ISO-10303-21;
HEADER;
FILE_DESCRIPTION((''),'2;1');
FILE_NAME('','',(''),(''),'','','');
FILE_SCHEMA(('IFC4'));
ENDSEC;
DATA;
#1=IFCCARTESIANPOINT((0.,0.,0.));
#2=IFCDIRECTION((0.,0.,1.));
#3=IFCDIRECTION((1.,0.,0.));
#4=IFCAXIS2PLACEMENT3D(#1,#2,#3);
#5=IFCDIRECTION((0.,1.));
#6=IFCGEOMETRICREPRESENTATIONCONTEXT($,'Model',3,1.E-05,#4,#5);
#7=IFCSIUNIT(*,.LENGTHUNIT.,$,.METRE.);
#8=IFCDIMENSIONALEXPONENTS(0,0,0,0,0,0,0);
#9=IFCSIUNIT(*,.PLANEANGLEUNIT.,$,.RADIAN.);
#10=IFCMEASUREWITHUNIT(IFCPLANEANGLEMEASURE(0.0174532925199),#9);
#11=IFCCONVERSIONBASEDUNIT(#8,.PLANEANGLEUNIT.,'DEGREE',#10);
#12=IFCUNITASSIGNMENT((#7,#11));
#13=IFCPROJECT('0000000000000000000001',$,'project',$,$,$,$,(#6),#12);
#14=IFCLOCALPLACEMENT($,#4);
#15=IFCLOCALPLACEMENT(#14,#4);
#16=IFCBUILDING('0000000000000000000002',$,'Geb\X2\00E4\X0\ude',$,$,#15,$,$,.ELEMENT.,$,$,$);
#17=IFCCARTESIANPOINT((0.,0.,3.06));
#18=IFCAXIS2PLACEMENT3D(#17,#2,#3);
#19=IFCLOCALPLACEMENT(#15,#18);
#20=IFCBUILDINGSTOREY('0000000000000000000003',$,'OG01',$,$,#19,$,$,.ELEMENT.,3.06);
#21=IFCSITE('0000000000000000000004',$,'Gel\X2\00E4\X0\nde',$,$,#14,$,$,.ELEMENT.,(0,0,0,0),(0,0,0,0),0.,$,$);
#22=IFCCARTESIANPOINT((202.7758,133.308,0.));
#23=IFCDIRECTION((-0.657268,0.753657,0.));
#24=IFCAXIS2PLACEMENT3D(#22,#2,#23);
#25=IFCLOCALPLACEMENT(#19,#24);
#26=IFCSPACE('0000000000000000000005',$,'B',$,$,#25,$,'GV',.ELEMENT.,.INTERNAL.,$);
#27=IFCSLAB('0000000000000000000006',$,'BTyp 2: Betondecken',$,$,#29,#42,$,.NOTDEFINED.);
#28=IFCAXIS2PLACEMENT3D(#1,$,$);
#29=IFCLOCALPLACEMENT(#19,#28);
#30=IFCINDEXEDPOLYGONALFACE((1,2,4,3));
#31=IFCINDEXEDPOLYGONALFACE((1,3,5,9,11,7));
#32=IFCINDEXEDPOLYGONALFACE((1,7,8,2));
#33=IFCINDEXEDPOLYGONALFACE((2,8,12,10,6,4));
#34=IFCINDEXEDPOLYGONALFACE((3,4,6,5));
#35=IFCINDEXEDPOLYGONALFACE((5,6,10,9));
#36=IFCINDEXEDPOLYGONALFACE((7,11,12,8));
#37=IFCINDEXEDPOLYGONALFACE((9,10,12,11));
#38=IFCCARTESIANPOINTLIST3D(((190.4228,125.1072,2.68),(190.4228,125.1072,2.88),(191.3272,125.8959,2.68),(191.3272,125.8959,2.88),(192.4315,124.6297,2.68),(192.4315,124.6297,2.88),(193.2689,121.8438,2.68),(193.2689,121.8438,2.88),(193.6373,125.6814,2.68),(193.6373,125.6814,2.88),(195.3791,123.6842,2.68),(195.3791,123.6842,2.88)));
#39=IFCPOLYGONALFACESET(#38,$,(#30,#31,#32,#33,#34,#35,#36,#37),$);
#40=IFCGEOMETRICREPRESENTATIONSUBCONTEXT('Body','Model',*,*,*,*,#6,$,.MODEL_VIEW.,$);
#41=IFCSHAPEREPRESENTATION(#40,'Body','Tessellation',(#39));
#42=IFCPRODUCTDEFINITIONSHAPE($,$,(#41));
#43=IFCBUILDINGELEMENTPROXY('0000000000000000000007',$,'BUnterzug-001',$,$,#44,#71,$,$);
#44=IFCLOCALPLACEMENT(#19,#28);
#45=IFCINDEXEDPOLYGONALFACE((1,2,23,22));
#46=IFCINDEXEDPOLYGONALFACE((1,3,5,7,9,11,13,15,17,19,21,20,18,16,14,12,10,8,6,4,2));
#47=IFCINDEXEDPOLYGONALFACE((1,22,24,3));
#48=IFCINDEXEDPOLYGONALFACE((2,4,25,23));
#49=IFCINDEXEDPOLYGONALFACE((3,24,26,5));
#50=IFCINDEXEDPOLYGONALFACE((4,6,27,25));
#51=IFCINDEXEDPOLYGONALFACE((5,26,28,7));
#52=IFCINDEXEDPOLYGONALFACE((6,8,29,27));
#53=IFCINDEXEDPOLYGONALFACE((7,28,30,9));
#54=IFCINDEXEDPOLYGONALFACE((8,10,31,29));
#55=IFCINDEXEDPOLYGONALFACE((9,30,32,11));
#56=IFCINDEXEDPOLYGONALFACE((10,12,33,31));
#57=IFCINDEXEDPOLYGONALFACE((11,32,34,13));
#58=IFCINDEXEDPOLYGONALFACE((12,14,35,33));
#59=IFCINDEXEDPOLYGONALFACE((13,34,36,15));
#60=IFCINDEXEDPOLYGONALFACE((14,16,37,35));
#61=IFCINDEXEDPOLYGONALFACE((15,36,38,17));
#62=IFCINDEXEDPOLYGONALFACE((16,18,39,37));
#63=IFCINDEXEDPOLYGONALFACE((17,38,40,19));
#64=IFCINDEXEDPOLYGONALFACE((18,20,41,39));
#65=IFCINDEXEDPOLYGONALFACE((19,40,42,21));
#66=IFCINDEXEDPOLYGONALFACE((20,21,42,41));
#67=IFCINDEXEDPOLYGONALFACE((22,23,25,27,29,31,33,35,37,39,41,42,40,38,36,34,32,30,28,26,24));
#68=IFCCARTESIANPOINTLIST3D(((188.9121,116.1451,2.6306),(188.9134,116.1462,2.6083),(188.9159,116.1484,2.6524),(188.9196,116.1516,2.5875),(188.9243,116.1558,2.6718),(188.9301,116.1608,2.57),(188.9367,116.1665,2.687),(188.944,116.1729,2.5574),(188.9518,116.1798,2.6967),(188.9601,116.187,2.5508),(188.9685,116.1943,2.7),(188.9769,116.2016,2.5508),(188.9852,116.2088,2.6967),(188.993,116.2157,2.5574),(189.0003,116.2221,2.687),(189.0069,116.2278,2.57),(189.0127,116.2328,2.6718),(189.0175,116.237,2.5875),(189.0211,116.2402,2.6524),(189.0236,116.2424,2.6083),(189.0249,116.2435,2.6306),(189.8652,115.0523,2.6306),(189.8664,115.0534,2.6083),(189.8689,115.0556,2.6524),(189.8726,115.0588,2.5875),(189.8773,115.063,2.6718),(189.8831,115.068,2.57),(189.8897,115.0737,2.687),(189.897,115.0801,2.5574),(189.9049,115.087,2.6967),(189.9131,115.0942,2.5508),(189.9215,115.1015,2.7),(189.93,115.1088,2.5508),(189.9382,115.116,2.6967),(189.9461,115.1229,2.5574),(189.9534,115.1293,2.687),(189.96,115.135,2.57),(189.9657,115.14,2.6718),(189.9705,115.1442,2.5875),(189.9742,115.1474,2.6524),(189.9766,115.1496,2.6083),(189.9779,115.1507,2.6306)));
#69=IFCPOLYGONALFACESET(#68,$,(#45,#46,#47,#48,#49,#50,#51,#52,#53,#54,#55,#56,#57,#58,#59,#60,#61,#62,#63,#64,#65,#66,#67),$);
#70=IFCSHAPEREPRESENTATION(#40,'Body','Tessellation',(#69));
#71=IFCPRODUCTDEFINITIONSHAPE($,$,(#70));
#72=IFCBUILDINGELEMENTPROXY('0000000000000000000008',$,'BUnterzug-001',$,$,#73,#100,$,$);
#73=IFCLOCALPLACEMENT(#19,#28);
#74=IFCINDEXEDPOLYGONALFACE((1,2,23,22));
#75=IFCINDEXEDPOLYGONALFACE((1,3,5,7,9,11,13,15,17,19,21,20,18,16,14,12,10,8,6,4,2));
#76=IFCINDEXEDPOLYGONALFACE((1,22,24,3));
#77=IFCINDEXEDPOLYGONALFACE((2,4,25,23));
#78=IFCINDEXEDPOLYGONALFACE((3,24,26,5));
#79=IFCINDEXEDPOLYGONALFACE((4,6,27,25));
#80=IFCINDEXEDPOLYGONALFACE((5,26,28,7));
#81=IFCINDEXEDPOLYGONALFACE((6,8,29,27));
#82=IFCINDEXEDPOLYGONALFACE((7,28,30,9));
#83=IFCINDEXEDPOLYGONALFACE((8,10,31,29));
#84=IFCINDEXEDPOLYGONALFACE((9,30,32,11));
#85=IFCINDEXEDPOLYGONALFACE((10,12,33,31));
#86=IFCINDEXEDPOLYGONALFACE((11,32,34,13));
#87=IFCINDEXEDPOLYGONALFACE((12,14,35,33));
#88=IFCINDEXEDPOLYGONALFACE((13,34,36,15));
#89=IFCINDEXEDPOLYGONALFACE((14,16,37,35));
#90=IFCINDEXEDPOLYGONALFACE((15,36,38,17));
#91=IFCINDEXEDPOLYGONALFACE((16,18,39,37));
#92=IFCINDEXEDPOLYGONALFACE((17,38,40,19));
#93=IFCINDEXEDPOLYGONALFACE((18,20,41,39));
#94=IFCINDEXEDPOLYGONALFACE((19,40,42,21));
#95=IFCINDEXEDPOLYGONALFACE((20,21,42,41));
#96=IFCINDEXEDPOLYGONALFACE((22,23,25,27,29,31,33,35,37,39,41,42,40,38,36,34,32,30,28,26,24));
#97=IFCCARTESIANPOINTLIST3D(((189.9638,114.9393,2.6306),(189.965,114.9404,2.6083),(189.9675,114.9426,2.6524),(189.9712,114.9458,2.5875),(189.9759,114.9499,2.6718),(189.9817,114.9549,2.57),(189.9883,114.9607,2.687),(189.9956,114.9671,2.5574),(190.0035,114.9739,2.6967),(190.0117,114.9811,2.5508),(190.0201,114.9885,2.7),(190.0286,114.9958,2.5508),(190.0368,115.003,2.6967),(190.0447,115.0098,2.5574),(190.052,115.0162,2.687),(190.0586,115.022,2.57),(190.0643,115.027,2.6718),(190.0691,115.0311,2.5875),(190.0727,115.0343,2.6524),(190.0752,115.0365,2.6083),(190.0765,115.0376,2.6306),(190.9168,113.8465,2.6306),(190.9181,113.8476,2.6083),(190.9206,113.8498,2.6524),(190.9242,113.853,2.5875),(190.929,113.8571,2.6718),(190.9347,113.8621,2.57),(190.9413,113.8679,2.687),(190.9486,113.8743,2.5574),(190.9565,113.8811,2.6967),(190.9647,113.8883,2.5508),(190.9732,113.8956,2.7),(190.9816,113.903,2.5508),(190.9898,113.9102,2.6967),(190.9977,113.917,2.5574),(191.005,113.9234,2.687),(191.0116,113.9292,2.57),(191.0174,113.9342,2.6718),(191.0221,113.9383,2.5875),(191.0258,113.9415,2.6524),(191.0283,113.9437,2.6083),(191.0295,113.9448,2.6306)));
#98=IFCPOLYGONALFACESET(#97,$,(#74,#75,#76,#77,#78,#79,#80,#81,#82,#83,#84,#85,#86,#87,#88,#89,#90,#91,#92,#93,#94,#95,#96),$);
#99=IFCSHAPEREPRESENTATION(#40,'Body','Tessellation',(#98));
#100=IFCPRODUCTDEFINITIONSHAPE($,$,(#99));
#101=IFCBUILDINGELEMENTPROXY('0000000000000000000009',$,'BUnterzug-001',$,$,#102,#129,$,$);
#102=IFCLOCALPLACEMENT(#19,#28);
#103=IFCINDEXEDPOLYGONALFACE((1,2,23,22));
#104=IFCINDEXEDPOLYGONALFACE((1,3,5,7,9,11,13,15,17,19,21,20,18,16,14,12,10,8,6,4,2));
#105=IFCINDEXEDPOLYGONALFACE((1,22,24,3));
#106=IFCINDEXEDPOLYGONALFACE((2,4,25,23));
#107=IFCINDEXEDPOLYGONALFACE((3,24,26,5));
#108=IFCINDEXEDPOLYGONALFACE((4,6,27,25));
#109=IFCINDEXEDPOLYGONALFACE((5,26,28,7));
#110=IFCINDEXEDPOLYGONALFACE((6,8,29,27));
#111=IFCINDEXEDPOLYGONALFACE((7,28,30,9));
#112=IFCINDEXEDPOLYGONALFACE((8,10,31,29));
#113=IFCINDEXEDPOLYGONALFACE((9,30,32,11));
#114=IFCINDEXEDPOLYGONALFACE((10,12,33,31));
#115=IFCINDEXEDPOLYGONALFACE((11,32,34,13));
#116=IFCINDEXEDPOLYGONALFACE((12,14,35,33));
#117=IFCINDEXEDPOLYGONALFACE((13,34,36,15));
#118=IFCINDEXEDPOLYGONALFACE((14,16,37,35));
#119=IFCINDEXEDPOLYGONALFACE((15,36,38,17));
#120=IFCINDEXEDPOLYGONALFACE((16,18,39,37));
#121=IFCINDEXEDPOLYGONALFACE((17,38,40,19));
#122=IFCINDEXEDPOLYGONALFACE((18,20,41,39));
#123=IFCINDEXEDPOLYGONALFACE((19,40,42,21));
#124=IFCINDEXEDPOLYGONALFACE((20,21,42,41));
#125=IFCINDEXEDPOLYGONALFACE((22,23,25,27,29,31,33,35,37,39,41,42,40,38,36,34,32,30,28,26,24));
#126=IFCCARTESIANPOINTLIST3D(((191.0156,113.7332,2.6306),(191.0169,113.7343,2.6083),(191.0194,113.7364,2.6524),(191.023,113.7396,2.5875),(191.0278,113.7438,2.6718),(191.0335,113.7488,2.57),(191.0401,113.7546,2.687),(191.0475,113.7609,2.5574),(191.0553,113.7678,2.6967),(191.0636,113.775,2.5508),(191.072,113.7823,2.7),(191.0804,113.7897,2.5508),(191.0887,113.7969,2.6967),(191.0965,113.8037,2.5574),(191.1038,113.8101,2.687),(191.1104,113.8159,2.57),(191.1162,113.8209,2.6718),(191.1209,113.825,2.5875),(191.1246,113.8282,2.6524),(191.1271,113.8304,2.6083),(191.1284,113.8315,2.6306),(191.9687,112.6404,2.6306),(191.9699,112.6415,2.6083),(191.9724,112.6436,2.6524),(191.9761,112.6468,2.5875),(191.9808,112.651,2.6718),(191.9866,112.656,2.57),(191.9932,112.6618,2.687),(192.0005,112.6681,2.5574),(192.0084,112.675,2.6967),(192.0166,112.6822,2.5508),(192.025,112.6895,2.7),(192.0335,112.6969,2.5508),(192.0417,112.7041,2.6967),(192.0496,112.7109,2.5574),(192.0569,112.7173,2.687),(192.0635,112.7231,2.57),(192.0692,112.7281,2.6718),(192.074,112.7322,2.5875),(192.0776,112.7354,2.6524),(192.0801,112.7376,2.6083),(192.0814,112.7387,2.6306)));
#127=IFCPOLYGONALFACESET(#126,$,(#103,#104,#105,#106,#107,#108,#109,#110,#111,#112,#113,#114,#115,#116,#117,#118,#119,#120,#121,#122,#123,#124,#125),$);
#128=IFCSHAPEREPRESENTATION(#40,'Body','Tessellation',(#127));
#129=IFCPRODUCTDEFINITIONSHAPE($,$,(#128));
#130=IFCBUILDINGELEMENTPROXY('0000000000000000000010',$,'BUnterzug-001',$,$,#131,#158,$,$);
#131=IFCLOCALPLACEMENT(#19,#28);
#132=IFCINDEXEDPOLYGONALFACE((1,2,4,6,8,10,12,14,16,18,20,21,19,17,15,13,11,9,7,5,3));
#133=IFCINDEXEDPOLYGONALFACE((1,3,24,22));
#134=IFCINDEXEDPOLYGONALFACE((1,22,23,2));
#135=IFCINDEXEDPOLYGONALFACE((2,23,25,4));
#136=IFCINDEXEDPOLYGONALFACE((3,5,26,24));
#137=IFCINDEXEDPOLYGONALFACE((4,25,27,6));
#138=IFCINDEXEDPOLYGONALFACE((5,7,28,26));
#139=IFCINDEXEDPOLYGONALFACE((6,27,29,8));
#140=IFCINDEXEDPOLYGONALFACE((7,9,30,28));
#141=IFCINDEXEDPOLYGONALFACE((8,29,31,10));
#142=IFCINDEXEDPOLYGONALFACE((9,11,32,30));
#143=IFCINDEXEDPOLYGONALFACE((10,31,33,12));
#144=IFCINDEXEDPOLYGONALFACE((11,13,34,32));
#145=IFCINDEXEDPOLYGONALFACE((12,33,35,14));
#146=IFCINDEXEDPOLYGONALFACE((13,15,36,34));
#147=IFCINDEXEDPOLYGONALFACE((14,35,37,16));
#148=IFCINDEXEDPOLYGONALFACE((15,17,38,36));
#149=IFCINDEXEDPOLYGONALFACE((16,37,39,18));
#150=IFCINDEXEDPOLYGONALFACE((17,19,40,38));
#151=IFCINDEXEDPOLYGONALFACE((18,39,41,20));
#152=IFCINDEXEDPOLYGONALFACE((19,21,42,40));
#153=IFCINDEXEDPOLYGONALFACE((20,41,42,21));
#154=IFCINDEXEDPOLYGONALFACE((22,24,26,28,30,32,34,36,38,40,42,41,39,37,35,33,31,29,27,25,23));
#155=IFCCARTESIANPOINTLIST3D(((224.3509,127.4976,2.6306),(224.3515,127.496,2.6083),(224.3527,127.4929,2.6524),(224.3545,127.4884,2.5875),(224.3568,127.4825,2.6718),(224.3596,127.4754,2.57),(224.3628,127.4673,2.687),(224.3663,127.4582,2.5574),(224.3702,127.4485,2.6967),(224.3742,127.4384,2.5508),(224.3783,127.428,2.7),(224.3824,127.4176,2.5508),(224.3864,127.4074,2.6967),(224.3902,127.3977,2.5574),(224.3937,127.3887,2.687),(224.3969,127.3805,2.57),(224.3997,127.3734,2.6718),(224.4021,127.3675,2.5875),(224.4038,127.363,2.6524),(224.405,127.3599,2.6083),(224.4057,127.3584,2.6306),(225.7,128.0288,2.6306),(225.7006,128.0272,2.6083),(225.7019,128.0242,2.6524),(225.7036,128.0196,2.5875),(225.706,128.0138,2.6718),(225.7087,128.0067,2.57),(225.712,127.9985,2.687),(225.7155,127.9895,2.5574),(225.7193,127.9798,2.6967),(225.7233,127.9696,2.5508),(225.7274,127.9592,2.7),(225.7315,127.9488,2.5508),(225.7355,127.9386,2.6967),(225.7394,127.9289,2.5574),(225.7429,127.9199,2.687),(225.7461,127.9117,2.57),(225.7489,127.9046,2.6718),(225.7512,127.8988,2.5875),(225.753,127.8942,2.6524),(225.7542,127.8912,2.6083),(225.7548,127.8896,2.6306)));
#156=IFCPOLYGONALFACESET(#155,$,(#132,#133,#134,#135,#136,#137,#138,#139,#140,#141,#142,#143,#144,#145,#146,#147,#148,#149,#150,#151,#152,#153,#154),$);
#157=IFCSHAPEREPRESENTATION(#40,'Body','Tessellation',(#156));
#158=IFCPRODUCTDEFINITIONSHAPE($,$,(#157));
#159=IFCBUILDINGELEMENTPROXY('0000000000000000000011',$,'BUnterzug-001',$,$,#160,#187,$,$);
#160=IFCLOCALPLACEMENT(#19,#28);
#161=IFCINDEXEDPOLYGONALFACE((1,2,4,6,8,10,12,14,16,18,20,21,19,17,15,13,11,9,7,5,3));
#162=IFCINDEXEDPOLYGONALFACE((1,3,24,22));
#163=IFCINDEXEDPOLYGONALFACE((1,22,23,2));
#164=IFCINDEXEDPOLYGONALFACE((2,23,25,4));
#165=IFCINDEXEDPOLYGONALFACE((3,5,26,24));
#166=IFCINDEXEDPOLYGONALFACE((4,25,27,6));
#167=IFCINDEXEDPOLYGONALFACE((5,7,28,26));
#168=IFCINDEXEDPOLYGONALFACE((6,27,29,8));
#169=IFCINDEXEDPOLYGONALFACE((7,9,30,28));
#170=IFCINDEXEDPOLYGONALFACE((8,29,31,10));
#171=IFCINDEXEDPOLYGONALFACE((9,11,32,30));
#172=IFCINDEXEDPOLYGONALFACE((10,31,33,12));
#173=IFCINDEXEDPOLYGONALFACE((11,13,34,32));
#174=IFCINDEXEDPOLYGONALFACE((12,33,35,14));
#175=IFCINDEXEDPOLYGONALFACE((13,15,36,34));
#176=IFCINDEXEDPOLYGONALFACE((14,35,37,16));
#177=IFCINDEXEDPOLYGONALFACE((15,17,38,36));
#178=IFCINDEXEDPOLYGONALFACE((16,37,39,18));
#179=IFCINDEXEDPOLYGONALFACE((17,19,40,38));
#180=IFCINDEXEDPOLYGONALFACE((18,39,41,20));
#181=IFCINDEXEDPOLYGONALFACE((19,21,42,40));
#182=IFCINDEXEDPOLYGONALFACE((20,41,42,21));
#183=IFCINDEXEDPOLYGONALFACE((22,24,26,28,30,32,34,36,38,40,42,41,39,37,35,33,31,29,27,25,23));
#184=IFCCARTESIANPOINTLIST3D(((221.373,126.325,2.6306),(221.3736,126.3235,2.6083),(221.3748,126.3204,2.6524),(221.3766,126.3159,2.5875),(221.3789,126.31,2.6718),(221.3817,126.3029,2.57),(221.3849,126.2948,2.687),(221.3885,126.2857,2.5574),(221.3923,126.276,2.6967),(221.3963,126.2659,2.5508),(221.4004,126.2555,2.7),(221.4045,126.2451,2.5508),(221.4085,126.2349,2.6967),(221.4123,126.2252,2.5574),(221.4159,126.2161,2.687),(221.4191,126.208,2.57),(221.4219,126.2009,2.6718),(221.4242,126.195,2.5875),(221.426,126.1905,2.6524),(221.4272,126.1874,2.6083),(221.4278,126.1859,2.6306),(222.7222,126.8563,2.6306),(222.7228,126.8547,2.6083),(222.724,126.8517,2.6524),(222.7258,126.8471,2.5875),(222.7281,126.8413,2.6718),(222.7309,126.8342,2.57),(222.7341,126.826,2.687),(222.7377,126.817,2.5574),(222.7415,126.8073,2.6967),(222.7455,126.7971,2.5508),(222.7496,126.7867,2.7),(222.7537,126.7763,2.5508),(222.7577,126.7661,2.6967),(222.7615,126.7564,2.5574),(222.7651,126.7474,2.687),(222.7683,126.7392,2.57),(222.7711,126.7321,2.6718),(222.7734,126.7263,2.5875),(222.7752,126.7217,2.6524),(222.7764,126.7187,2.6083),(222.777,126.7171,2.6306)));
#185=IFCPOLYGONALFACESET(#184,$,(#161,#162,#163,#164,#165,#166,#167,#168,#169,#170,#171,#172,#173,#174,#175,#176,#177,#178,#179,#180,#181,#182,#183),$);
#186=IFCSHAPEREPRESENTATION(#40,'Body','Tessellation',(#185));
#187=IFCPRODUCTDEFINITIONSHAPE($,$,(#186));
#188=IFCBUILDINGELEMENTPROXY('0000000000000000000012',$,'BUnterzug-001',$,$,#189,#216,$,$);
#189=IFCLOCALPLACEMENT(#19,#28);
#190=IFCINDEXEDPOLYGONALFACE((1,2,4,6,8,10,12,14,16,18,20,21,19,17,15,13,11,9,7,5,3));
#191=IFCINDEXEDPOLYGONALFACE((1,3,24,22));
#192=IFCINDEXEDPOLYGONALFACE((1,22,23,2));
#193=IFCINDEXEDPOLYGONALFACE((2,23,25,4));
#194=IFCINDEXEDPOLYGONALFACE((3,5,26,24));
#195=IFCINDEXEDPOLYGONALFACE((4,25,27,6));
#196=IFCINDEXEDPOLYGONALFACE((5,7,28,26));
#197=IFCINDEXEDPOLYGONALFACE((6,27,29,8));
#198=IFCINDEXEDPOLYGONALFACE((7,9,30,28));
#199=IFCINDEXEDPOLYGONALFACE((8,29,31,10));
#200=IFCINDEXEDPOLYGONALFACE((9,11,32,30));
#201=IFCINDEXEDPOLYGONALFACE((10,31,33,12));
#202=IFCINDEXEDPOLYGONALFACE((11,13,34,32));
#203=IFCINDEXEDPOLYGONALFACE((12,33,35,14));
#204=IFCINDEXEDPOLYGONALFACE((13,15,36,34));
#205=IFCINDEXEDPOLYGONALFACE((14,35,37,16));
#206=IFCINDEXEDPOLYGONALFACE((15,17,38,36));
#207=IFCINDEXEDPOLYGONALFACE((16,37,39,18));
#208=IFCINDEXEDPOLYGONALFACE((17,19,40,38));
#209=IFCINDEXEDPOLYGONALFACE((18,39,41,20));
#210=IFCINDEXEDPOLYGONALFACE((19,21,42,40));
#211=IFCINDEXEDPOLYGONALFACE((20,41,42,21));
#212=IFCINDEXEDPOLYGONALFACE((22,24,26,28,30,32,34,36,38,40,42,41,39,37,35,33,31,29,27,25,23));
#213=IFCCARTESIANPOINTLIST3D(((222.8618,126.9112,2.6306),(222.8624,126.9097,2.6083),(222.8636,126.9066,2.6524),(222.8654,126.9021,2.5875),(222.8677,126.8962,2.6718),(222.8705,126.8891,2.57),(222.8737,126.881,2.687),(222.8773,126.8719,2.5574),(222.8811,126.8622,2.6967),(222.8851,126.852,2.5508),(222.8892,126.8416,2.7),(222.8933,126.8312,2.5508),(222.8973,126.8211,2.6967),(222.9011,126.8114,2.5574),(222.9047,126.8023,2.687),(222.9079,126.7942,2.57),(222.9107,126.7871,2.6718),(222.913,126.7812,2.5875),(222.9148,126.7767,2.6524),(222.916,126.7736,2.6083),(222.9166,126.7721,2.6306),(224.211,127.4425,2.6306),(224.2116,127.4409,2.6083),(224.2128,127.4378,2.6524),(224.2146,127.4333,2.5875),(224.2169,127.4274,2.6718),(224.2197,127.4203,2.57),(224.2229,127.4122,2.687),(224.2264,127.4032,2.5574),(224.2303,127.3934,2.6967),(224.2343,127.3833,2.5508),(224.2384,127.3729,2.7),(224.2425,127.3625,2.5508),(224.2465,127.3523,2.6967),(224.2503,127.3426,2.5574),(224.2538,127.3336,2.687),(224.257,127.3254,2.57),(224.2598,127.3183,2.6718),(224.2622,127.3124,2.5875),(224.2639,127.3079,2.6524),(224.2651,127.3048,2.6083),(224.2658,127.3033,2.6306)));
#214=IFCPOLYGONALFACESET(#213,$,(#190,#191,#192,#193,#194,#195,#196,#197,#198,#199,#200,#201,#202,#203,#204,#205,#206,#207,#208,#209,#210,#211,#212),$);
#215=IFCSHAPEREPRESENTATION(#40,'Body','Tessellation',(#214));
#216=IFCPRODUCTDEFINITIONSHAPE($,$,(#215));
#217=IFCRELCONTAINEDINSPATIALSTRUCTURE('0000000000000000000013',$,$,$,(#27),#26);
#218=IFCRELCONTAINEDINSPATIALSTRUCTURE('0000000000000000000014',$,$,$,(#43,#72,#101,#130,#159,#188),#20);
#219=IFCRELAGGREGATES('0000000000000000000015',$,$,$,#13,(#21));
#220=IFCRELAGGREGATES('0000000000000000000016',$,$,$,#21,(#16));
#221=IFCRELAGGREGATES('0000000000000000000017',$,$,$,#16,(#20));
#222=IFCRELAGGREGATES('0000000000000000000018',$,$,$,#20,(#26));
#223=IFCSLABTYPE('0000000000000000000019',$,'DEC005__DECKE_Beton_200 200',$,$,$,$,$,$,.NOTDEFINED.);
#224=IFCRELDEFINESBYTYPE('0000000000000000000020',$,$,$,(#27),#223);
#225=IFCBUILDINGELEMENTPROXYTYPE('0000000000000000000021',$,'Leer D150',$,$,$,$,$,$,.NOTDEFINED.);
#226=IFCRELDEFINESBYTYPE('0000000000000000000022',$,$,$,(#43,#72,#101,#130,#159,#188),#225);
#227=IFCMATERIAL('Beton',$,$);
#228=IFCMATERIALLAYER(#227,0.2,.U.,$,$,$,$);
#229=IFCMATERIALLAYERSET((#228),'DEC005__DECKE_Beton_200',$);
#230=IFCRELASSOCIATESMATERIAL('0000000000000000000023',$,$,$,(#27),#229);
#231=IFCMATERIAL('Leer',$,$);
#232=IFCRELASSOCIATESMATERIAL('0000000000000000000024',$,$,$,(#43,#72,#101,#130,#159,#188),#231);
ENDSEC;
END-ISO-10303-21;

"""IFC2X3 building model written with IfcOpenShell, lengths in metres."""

from ifc_helpers import new_model, entity, si_unit, converted_unit, direction, frame, frame_2d, origin_with_axes, place, context, subcontext, project, spatial, polyline, circle, outline, extrude, material, layer, layer_set, layer_usage, type_object, element, save


model = new_model("IFC2X3")

# Units and contexts
model_context = context("Model", 3, precision=1e-05, world=origin_with_axes(), true_north=direction((0.0, 1.0)))
body_context = subcontext(model_context, "Body", "Model", "MODEL_VIEW")
ifc_project = project(units=[si_unit("LENGTHUNIT", "METRE"), converted_unit("PLANEANGLEUNIT", "DEGREE", entity("IfcPlaneAngleMeasure", 0.0174532925199), si_unit("PLANEANGLEUNIT", "RADIAN"), dimensions=[0, 0, 0, 0, 0, 0, 0])], contexts=[model_context])

# Site, building, storey
site_placement = place(None, origin_with_axes())
site = spatial("IfcSite", under=ifc_project, at=site_placement, Name="Gelände", CompositionType="ELEMENT", RefLatitude=(0, 0, 0, 0), RefLongitude=(0, 0, 0, 0), RefElevation=0.0)
building_placement = place(site_placement, origin_with_axes())
building = spatial("IfcBuilding", under=site, at=building_placement, Name="Gebäude", CompositionType="ELEMENT")
storey_placement = place(building_placement, frame((0.0, 0.0, 3.06), z_axis=(0.0, 0.0, 1.0), x_axis=(1.0, 0.0, 0.0)))
storey = spatial("IfcBuildingStorey", under=building, at=storey_placement, Name="OG01", CompositionType="ELEMENT", Elevation=3.06)

# Shared definitions
space_1_placement = place(storey_placement, frame((202.7758, 133.308, 0.0), z_axis=(0.0, 0.0, 1.0), x_axis=(-0.657268, 0.753657, 0.0)))
space_1 = spatial("IfcSpace", under=storey, at=space_1_placement, Name="B", LongName="GV", CompositionType="ELEMENT", InteriorOrExteriorSpace="INTERNAL")

# Slab
ifc_material_1 = material(Name="Beton")
ifc_layer_1 = layer(ifc_material_1, 0.2, ventilated="UNKNOWN")
ifc_layer_set_1 = layer_set([ifc_layer_1], Name="DEC005__DECKE_Beton_200")
ifc_layer_usage_1 = layer_usage(ifc_layer_set_1, "AXIS3", "NEGATIVE", 0.2)
slab_type_1 = type_object("IfcSlabType", Name="DEC005__DECKE_Beton_200 200", PredefinedType="NOTDEFINED")
slab_1_placement = place(space_1_placement, frame((0.2585, 11.9, 2.88), z_axis=(0.0, 0.0, 1.0), x_axis=(-0.657268, -0.753657, 0.0)))
element("IfcSlab", 1, at=slab_1_placement, inside=space_1, type_object=slab_type_1, material=ifc_layer_usage_1, Name="BTyp 2: Betondecken", PredefinedType="NOTDEFINED", context=body_context, shape_type="SweptSolid", body=[
    extrude(outline(polyline([(0.0, 0.0), (-1.2059, -1.0516), (-2.3101, 0.2146), (-3.2145, -0.5741), (-0.3685, -3.8375), (1.7418, -1.9972), (0.0, 0.0)])), frame((0.0, 0.0, -0.2), z_axis=(0.0, 0.0, 1.0), x_axis=(1.0, 0.0, 0.0)), (0.0, 0.0, 1.0), 0.2),
])

# Building element proxies
ifc_material_2 = material(Name="Leer")
building_element_proxy_type_1 = type_object("IfcBuildingElementProxyType", Name="Leer D150", PredefinedType="NOTDEFINED")
for number, where, z_axis, x_axis, name in (
    (2, (188.9685, 116.1943, 2.7), (0.0, 0.0, 1.0), (-0.753657, -0.657268, 0.0), "BUnterzug-001"),
    (3, (190.0201, 114.9885, 2.7), (0.0, 0.0, 1.0), (-0.753657, -0.657268, 0.0), "BUnterzug-001"),
    (4, (191.072, 113.7823, 2.7), (0.0, 0.0, 1.0), (-0.753657, -0.657268, 0.0), "BUnterzug-001"),
    (5, (224.3783, 127.428, 2.7), (0.0, 0.0, 1.0), (0.366369, -0.93047, 0.0), "BUnterzug-001"),
    (6, (221.4004, 126.2555, 2.7), (0.0, 0.0, 1.0), (0.366369, -0.93047, 0.0), "BUnterzug-001"),
    (7, (222.8892, 126.8416, 2.7), (0.0, 0.0, 1.0), (0.366369, -0.93047, 0.0), "BUnterzug-001"),
):
    element("IfcBuildingElementProxy", number, at=place(storey_placement, frame(where, z_axis=z_axis, x_axis=x_axis)), inside=storey, type_object=building_element_proxy_type_1, material=ifc_material_2, Name=name, context=body_context, shape_type="SweptSolid", body=[
        extrude(circle(Radius=0.075, at=frame_2d((-0.075, 0.0), x_axis=(1.0, 0.0))), frame((0.0, 0.0, 0.0), z_axis=(0.0, 1.0, 0.0), x_axis=(0.0, 0.0, 1.0)), (0.0, 0.0, 1.0), 1.45),
    ])

save(model, "model.ifc")
